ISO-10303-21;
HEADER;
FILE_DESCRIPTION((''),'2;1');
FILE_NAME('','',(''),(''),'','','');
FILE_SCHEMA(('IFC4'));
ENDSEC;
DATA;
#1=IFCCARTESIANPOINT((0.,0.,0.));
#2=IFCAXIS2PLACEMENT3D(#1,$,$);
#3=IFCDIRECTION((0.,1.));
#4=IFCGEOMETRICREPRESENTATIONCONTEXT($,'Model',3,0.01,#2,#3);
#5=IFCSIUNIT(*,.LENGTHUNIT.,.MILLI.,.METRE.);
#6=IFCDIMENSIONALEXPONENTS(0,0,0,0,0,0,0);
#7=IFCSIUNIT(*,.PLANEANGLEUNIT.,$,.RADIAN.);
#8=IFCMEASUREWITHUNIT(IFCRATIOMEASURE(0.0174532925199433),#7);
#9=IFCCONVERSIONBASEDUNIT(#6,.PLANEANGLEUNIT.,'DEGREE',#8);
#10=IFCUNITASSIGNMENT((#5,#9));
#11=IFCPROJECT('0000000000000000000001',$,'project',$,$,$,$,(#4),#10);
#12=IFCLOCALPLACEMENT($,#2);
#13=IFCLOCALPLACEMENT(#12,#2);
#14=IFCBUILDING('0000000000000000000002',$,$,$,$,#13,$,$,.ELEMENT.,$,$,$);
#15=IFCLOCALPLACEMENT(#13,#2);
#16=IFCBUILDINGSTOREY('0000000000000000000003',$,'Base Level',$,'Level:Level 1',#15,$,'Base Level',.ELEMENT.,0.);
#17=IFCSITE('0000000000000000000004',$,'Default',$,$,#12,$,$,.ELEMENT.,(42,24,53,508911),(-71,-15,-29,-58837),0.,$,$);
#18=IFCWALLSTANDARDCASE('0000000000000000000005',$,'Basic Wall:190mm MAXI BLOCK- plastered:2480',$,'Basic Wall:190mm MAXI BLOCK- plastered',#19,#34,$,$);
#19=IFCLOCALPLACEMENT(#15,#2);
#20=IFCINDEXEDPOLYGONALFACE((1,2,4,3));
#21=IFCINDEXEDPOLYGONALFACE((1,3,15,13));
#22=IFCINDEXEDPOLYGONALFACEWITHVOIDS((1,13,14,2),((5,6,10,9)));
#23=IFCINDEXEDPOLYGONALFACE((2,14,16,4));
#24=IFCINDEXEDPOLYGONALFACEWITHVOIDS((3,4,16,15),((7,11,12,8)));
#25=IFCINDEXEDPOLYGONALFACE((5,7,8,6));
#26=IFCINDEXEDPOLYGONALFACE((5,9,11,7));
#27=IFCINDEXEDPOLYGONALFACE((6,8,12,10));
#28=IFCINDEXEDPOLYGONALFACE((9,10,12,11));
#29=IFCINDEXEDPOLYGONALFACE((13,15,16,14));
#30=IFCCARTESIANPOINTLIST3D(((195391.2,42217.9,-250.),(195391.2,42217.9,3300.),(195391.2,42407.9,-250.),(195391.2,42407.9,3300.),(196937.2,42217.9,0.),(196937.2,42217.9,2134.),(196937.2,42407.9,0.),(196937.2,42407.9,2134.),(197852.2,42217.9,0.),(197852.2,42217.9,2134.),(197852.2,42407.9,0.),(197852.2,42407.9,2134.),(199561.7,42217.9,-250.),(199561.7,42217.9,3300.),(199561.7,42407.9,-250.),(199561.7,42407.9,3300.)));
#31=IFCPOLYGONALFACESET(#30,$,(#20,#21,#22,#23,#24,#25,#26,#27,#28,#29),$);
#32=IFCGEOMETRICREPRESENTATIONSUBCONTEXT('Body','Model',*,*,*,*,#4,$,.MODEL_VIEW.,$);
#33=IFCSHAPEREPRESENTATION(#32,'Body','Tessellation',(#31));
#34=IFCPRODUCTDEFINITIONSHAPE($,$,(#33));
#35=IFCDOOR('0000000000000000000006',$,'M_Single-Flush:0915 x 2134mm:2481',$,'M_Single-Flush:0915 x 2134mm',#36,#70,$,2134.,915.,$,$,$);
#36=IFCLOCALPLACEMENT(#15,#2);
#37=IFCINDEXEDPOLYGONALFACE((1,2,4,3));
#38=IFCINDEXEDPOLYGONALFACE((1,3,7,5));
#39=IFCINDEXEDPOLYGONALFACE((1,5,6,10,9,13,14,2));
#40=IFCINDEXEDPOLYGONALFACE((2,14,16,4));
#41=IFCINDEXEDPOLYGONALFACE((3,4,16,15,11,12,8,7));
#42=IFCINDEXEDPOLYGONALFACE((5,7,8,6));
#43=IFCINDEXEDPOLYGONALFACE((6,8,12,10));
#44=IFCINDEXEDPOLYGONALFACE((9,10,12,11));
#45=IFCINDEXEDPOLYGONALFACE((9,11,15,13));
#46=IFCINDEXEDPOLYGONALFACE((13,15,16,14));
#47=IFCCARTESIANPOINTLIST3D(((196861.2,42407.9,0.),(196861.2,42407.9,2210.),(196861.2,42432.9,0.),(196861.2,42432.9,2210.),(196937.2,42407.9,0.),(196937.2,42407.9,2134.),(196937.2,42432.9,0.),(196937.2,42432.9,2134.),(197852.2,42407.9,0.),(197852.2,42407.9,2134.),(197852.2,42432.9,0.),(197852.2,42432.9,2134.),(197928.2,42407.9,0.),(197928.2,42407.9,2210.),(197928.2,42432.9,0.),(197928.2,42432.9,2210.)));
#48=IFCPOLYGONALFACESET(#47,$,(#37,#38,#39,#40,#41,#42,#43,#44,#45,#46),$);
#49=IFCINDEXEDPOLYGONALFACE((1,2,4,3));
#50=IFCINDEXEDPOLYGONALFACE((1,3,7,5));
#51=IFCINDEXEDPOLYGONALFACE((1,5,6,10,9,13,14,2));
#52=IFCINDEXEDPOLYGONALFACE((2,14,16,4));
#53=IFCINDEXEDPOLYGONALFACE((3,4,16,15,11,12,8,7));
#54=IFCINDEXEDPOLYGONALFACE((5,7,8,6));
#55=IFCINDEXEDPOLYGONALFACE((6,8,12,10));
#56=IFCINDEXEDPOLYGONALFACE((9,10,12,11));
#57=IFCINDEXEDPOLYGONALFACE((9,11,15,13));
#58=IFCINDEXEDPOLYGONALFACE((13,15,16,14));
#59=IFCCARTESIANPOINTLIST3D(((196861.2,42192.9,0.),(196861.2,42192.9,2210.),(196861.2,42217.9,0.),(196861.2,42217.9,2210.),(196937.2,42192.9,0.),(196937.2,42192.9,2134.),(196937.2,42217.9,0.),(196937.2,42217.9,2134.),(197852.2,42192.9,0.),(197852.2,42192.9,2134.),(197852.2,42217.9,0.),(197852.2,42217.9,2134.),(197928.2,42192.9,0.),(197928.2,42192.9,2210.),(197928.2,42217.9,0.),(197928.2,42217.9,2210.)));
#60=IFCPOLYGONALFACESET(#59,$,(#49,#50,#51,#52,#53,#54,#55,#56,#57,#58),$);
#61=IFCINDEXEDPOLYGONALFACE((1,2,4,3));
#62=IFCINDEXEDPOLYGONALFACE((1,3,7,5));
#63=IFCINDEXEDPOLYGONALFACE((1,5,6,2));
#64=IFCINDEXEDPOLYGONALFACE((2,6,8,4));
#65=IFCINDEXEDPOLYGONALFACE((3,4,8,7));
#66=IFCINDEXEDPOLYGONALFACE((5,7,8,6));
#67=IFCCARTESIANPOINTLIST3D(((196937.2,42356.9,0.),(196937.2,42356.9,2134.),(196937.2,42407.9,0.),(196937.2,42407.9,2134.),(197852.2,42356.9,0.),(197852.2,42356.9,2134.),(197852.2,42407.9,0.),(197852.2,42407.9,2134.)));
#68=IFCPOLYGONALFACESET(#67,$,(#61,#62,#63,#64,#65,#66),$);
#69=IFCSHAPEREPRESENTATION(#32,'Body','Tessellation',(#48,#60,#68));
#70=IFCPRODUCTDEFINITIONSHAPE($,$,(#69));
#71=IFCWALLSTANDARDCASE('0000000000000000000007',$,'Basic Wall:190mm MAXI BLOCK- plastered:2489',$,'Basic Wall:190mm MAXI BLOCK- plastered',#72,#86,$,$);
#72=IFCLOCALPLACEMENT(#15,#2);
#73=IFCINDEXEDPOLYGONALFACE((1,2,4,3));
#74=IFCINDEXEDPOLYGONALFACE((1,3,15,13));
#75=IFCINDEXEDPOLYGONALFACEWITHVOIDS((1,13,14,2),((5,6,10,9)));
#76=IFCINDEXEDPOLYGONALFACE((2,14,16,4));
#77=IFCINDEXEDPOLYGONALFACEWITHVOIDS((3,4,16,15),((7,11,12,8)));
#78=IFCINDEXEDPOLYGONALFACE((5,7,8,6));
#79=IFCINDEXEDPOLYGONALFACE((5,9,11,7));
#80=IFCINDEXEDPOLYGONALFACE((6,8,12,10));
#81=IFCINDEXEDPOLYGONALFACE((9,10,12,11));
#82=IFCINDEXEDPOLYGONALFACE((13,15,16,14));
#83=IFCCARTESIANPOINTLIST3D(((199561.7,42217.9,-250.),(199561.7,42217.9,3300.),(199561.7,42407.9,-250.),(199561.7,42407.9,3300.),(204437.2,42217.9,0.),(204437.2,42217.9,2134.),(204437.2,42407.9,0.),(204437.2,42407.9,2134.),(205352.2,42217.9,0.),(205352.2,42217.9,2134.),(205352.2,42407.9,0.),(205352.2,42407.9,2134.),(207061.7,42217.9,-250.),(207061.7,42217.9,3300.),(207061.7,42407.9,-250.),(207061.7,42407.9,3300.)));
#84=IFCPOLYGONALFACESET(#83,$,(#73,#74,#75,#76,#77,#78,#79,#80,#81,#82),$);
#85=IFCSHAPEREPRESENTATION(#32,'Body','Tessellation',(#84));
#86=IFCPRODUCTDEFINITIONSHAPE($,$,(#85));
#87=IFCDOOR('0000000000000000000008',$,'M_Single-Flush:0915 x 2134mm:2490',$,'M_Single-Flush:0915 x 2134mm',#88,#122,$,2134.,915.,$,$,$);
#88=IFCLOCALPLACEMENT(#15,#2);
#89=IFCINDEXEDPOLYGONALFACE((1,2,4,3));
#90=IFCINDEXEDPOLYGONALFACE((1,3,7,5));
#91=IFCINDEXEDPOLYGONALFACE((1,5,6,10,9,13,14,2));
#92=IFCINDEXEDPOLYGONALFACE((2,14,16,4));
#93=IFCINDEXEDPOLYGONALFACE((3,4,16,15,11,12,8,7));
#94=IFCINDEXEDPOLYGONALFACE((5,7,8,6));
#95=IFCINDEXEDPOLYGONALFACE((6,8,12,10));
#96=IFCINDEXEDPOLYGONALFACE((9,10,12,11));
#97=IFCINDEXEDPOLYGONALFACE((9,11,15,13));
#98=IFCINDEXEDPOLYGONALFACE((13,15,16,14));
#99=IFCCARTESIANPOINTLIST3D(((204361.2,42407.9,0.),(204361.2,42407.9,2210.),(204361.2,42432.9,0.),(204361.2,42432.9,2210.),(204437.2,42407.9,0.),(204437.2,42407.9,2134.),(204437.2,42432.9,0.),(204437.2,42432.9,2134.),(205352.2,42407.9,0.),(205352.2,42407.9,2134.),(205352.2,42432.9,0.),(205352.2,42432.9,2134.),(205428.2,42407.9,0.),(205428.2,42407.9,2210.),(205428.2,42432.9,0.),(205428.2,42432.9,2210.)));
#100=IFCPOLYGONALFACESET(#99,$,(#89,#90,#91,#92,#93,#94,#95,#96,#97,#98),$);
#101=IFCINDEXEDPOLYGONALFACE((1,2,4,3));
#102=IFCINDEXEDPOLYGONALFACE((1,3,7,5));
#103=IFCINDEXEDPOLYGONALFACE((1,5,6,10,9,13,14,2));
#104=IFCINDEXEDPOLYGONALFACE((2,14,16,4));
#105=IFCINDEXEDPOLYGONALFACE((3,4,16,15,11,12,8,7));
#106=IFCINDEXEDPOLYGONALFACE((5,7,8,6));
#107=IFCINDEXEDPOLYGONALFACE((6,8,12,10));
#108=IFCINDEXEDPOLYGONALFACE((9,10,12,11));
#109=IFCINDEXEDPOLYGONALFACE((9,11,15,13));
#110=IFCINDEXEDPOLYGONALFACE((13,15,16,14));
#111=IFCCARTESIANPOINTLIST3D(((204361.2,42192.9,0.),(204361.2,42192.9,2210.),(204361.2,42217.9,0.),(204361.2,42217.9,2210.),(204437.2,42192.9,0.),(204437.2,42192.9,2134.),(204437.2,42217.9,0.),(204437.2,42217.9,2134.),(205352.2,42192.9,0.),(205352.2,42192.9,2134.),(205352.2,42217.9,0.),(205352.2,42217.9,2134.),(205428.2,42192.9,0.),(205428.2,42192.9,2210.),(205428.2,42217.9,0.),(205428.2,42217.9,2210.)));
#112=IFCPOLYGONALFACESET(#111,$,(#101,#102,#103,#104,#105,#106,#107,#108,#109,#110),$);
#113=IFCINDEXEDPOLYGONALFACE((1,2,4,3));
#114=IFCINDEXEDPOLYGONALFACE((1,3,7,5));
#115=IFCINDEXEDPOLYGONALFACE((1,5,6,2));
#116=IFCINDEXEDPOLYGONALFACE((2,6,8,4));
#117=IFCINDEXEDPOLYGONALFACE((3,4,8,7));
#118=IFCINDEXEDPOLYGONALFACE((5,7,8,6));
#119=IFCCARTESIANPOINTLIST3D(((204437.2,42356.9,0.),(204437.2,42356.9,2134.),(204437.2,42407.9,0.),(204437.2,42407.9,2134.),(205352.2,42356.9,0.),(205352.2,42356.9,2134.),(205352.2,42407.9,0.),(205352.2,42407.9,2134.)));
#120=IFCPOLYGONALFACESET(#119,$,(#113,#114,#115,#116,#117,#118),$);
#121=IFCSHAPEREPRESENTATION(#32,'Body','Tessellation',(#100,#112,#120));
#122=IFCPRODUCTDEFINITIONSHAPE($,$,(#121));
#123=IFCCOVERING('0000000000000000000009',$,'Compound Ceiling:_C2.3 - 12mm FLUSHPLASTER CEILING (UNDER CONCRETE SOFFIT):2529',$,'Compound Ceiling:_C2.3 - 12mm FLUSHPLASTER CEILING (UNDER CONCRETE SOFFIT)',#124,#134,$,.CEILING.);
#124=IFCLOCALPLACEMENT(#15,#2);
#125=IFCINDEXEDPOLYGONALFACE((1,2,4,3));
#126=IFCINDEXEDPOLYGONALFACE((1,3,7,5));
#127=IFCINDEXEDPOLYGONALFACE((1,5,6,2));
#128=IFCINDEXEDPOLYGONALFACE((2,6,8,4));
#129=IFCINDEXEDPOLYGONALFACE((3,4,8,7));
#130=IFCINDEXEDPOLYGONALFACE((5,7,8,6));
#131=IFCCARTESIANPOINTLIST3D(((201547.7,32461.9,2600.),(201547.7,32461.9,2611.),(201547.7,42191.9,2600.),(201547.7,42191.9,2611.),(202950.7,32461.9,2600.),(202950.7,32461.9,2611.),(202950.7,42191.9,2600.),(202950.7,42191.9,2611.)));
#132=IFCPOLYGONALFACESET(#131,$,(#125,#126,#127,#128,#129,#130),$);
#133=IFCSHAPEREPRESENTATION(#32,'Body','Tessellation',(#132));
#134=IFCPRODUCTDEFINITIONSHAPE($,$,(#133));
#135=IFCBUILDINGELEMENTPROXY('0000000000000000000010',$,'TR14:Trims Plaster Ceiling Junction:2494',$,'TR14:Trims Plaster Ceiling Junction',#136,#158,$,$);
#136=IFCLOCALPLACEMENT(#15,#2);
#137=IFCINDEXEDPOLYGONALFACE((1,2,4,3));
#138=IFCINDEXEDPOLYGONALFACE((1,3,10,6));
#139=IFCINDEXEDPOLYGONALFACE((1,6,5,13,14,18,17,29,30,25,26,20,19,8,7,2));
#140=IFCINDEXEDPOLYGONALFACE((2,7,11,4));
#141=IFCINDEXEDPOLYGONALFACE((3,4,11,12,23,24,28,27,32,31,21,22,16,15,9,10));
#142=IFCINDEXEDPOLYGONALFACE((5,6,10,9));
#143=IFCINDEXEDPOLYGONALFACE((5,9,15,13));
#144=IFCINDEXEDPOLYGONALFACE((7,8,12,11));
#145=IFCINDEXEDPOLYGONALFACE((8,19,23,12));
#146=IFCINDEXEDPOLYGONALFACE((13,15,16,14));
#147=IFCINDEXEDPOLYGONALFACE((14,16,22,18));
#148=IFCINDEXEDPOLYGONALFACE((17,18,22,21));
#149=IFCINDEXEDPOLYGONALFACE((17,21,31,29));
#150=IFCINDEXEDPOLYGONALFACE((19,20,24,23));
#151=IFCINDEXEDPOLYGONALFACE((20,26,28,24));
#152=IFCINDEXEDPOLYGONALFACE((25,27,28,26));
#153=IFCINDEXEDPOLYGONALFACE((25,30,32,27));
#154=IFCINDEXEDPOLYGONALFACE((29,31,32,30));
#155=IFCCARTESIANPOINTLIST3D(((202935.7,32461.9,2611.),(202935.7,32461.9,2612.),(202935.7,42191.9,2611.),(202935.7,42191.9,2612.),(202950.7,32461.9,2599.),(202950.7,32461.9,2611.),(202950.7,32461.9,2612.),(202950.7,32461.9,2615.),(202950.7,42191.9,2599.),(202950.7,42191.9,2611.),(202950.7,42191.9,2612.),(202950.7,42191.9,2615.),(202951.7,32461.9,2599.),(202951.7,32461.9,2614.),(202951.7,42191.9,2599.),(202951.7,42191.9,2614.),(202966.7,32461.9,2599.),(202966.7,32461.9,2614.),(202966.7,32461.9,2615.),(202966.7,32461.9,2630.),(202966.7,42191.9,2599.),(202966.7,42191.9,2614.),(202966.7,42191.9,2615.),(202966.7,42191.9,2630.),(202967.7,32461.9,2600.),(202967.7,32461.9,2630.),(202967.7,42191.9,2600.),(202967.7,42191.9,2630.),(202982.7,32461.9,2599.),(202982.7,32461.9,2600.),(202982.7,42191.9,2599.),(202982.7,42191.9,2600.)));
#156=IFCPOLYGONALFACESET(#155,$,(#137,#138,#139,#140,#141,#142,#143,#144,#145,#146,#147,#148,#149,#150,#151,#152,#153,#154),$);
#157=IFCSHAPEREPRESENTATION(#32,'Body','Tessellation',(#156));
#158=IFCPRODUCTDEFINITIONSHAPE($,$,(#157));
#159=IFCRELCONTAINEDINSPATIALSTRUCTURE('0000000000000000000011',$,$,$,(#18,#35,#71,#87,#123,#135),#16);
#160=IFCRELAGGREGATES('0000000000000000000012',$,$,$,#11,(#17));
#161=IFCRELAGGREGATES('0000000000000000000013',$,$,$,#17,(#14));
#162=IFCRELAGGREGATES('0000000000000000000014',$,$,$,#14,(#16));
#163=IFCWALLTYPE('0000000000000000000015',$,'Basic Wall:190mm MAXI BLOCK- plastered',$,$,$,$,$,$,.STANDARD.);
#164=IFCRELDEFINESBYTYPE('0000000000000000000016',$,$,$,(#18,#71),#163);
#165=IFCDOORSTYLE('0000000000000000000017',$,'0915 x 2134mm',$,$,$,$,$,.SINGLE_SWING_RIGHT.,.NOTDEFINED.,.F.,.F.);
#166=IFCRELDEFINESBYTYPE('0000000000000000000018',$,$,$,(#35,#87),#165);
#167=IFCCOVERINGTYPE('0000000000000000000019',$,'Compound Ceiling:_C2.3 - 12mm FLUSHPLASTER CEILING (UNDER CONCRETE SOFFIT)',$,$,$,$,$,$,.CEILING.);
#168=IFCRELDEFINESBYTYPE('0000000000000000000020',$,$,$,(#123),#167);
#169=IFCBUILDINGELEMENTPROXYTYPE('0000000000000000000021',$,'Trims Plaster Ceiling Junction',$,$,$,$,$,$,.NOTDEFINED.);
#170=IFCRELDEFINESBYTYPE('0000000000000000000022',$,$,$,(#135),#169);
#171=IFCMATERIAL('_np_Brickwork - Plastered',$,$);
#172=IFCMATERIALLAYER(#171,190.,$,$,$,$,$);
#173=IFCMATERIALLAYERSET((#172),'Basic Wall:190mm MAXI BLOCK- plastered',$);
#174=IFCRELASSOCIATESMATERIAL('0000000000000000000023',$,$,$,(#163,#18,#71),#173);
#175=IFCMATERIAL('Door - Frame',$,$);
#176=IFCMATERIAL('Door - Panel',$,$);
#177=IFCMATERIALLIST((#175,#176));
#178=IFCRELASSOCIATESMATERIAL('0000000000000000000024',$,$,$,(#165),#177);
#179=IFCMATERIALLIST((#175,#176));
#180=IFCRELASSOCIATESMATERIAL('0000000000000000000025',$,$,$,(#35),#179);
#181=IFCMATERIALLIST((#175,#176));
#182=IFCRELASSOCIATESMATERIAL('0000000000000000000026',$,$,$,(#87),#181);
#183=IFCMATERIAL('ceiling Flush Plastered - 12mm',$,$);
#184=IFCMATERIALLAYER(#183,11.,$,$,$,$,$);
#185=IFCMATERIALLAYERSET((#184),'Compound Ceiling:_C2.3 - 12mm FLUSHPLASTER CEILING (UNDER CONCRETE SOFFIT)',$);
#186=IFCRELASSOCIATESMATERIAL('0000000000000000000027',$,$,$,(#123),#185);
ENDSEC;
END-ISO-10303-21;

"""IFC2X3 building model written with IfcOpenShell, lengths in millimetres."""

from ifc_helpers import new_model, entity, si_unit, converted_unit, direction, frame, frame_2d, origin, place, context, subcontext, project, spatial, polyline, rectangle, outline, extrude, source, transform, mapped, material, material_list, layer, layer_set, layer_usage, type_object, type_shapes, element, fill, save


model = new_model("IFC2X3")

# Units and contexts
model_context = context("Model", 3, precision=0.01, world=origin(), true_north=direction((0.0, 1.0)))
body_context = subcontext(model_context, "Body", "Model", "MODEL_VIEW")
ifc_project = project(units=[si_unit("LENGTHUNIT", "METRE", prefix="MILLI"), converted_unit("PLANEANGLEUNIT", "DEGREE", entity("IfcRatioMeasure", 0.0174532925199433), si_unit("PLANEANGLEUNIT", "RADIAN"), dimensions=[0, 0, 0, 0, 0, 0, 0])], contexts=[model_context])

# Site, building, storey
site_placement = place(None, origin())
site = spatial("IfcSite", under=ifc_project, at=site_placement, Name="Default", CompositionType="ELEMENT", RefLatitude=(42, 24, 53, 508911), RefLongitude=(-71, -15, -29, -58837), RefElevation=0.0)
building_placement = place(site_placement, origin())
building = spatial("IfcBuilding", under=site, at=building_placement, CompositionType="ELEMENT")
storey_placement = place(building_placement, origin())
storey = spatial("IfcBuildingStorey", under=building, at=storey_placement, Name="Base Level", ObjectType="Level:Level 1", LongName="Base Level", CompositionType="ELEMENT", Elevation=0.0)

# Walls, openings, doors
ifc_material_1 = material(Name="_np_Brickwork - Plastered")
ifc_layer_1 = layer(ifc_material_1, 190.0)
ifc_layer_set_1 = layer_set([ifc_layer_1], Name="Basic Wall:190mm MAXI BLOCK- plastered")
ifc_layer_usage_1 = layer_usage(ifc_layer_set_1, "AXIS2", "NEGATIVE", 95.0)
wall_type = type_object("IfcWallType", Name="Basic Wall:190mm MAXI BLOCK- plastered", PredefinedType="STANDARD", material=ifc_layer_set_1)
wall_1_placement = place(building_placement, frame((195391.2, 42312.9, -250.0)))
wall_1 = element("IfcWallStandardCase", 1, at=wall_1_placement, inside=storey, type_object=wall_type, material=ifc_layer_usage_1, Name="Basic Wall:190mm MAXI BLOCK- plastered:2480", ObjectType="Basic Wall:190mm MAXI BLOCK- plastered", context=body_context, shape_type="SweptSolid", body=[
    extrude(rectangle(XDim=4170.5, YDim=190.0, at=frame_2d((2085.3, 0.0), x_axis=(-1.0, 0.0))), origin(), (0.0, 0.0, 1.0), 3550.0),
])
opening_1_placement = place(wall_1_placement, frame((1546.0, -95.0, 250.0)))
opening_1 = element("IfcOpeningElement", 2, at=opening_1_placement, cuts=wall_1, ObjectType="Opening", context=body_context, shape_type="SweptSolid", body=[
    extrude(rectangle(XDim=915.0, YDim=2134.0, at=frame_2d((1067.0, 457.5), x_axis=(0.0, 1.0))), frame((0.0, 0.0, 0.0), z_axis=(0.0, 1.0, 0.0), x_axis=(0.0, 0.0, 1.0)), (0.0, 0.0, 1.0), 190.0),
])
ifc_material_2 = material(Name="Door - Frame")
ifc_material_3 = material(Name="Door - Panel")
ifc_material_list_1 = material_list([ifc_material_2, ifc_material_3])
ifc_material_list_2 = material_list([ifc_material_2, ifc_material_3])
door_style = type_object("IfcDoorStyle", Name="0915 x 2134mm", ConstructionType="NOTDEFINED", OperationType="SINGLE_SWING_RIGHT", ParameterTakesPrecedence=False, Sizeable=False, material=ifc_material_list_2)
shared_shape_1 = source(origin(), body_context, "Body", "SweptSolid", [
    extrude(outline(polyline([(-533.5, -1124.0), (533.5, -1124.0), (533.5, 1086.0), (457.5, 1086.0), (457.5, -1048.0), (-457.5, -1048.0), (-457.5, 1086.0), (-533.5, 1086.0), (-533.5, -1124.0)])), frame((457.5, 190.0, 1086.0), z_axis=(0.0, 1.0, 0.0), x_axis=(1.0, 0.0, 0.0)), (0.0, 0.0, 1.0), 25.0),
    extrude(outline(polyline([(-1124.0, -533.5), (1086.0, -533.5), (1086.0, -457.5), (-1048.0, -457.5), (-1048.0, 457.5), (1086.0, 457.5), (1086.0, 533.5), (-1124.0, 533.5), (-1124.0, -533.5)])), frame((457.5, -25.0, 1086.0), z_axis=(0.0, 1.0, 0.0), x_axis=(0.0, 0.0, -1.0)), (0.0, 0.0, 1.0), 25.0),
    extrude(rectangle(XDim=51.0, YDim=915.0, at=frame_2d((0.0, 0.0), x_axis=(1.0, 0.0))), frame((457.5, 164.5, 0.0), z_axis=(0.0, 0.0, 1.0), x_axis=(0.0, 1.0, 0.0)), (0.0, 0.0, 1.0), 2134.0),
])
type_shapes(door_style, [shared_shape_1])
door_1_placement = place(opening_1_placement, origin())
door_1 = element("IfcDoor", 3, at=door_1_placement, inside=storey, type_object=door_style, material=ifc_material_list_1, Name="M_Single-Flush:0915 x 2134mm:2481", ObjectType="M_Single-Flush:0915 x 2134mm", OverallHeight=2134.0, OverallWidth=915.0, context=body_context, shape_type="MappedRepresentation", body=[
    mapped(shared_shape_1, transform((0.0, 0.0, 0.0), scale=1.0)),
])
fill(opening_1, door_1)
ifc_layer_usage_2 = layer_usage(ifc_layer_set_1, "AXIS2", "NEGATIVE", 95.0)
wall_2_placement = place(building_placement, frame((199561.7, 42312.9, -250.0)))
wall_2 = element("IfcWallStandardCase", 4, at=wall_2_placement, inside=storey, type_object=wall_type, material=ifc_layer_usage_2, Name="Basic Wall:190mm MAXI BLOCK- plastered:2489", ObjectType="Basic Wall:190mm MAXI BLOCK- plastered", context=body_context, shape_type="SweptSolid", body=[
    extrude(rectangle(XDim=7500.0, YDim=190.0, at=frame_2d((3750.0, 0.0), x_axis=(-1.0, 0.0))), origin(), (0.0, 0.0, 1.0), 3550.0),
])
opening_2_placement = place(wall_2_placement, frame((4875.5, -95.0, 250.0)))
opening_2 = element("IfcOpeningElement", 5, at=opening_2_placement, cuts=wall_2, ObjectType="Opening", context=body_context, shape_type="SweptSolid", body=[
    extrude(rectangle(XDim=915.0, YDim=2134.0, at=frame_2d((1067.0, 457.5), x_axis=(0.0, 1.0))), frame((0.0, 0.0, 0.0), z_axis=(0.0, 1.0, 0.0), x_axis=(0.0, 0.0, 1.0)), (0.0, 0.0, 1.0), 190.0),
])
ifc_material_list_3 = material_list([ifc_material_2, ifc_material_3])
door_2_placement = place(opening_2_placement, origin())
door_2 = element("IfcDoor", 6, at=door_2_placement, inside=storey, type_object=door_style, material=ifc_material_list_3, Name="M_Single-Flush:0915 x 2134mm:2490", ObjectType="M_Single-Flush:0915 x 2134mm", OverallHeight=2134.0, OverallWidth=915.0, context=body_context, shape_type="MappedRepresentation", body=[
    mapped(shared_shape_1, transform((0.0, 0.0, 0.0), scale=1.0)),
])
fill(opening_2, door_2)

# Covering
ifc_material_4 = material(Name="ceiling Flush Plastered - 12mm")
ifc_layer_2 = layer(ifc_material_4, 11.0)
ifc_layer_set_2 = layer_set([ifc_layer_2], Name="Compound Ceiling:_C2.3 - 12mm FLUSHPLASTER CEILING (UNDER CONCRETE SOFFIT)")
ifc_layer_usage_3 = layer_usage(ifc_layer_set_2, "AXIS3", "POSITIVE", 0.0)
covering_type_1 = type_object("IfcCoveringType", Name="Compound Ceiling:_C2.3 - 12mm FLUSHPLASTER CEILING (UNDER CONCRETE SOFFIT)", PredefinedType="CEILING")
covering_1_placement = place(building_placement, origin())
element("IfcCovering", 7, at=covering_1_placement, inside=storey, type_object=covering_type_1, material=ifc_layer_usage_3, Name="Compound Ceiling:_C2.3 - 12mm FLUSHPLASTER CEILING (UNDER CONCRETE SOFFIT):2529", ObjectType="Compound Ceiling:_C2.3 - 12mm FLUSHPLASTER CEILING (UNDER CONCRETE SOFFIT)", PredefinedType="CEILING", context=body_context, shape_type="SweptSolid", body=[
    extrude(rectangle(XDim=9730.0, YDim=1403.0, at=frame_2d((0.0, 0.0), x_axis=(1.0, 0.0))), frame((202249.2, 37326.9, 2600.0), z_axis=(0.0, 0.0, 1.0), x_axis=(0.0, -1.0, 0.0)), (0.0, 0.0, 1.0), 11.0),
])

# Building element proxy
building_element_proxy_type = type_object("IfcBuildingElementProxyType", Name="Trims Plaster Ceiling Junction", PredefinedType="NOTDEFINED")
shared_shape_2 = source(origin(), body_context, "Body", "SweptSolid", [
    extrude(outline(polyline([(-20.0, 8.6), (-20.0, 7.6), (-5.0, 7.6), (-5.0, -8.4), (-2.0, -8.4), (-2.0, -23.4), (-1.0, -23.4), (-1.0, -8.4), (11.0, -8.4), (11.0, -7.4), (-4.0, -7.4), (-4.0, 7.6), (11.0, 7.6), (11.0, 23.6), (10.0, 23.6), (10.0, 8.6), (-20.0, 8.6)])), frame((202959.1, 32461.9, 2610.0), z_axis=(0.0, -1.0, 0.0), x_axis=(0.0, 0.0, -1.0)), (0.0, 0.0, -1.0), 9730.0),
])
type_shapes(building_element_proxy_type, [shared_shape_2])
proxy_placement = place(building_placement, origin())
element("IfcBuildingElementProxy", 8, at=proxy_placement, inside=storey, type_object=building_element_proxy_type, Name="TR14:Trims Plaster Ceiling Junction:2494", ObjectType="TR14:Trims Plaster Ceiling Junction", context=body_context, shape_type="MappedRepresentation", body=[
    mapped(shared_shape_2, transform((0.0, 0.0, 0.0), scale=1.0)),
])

save(model, "model.ifc")
